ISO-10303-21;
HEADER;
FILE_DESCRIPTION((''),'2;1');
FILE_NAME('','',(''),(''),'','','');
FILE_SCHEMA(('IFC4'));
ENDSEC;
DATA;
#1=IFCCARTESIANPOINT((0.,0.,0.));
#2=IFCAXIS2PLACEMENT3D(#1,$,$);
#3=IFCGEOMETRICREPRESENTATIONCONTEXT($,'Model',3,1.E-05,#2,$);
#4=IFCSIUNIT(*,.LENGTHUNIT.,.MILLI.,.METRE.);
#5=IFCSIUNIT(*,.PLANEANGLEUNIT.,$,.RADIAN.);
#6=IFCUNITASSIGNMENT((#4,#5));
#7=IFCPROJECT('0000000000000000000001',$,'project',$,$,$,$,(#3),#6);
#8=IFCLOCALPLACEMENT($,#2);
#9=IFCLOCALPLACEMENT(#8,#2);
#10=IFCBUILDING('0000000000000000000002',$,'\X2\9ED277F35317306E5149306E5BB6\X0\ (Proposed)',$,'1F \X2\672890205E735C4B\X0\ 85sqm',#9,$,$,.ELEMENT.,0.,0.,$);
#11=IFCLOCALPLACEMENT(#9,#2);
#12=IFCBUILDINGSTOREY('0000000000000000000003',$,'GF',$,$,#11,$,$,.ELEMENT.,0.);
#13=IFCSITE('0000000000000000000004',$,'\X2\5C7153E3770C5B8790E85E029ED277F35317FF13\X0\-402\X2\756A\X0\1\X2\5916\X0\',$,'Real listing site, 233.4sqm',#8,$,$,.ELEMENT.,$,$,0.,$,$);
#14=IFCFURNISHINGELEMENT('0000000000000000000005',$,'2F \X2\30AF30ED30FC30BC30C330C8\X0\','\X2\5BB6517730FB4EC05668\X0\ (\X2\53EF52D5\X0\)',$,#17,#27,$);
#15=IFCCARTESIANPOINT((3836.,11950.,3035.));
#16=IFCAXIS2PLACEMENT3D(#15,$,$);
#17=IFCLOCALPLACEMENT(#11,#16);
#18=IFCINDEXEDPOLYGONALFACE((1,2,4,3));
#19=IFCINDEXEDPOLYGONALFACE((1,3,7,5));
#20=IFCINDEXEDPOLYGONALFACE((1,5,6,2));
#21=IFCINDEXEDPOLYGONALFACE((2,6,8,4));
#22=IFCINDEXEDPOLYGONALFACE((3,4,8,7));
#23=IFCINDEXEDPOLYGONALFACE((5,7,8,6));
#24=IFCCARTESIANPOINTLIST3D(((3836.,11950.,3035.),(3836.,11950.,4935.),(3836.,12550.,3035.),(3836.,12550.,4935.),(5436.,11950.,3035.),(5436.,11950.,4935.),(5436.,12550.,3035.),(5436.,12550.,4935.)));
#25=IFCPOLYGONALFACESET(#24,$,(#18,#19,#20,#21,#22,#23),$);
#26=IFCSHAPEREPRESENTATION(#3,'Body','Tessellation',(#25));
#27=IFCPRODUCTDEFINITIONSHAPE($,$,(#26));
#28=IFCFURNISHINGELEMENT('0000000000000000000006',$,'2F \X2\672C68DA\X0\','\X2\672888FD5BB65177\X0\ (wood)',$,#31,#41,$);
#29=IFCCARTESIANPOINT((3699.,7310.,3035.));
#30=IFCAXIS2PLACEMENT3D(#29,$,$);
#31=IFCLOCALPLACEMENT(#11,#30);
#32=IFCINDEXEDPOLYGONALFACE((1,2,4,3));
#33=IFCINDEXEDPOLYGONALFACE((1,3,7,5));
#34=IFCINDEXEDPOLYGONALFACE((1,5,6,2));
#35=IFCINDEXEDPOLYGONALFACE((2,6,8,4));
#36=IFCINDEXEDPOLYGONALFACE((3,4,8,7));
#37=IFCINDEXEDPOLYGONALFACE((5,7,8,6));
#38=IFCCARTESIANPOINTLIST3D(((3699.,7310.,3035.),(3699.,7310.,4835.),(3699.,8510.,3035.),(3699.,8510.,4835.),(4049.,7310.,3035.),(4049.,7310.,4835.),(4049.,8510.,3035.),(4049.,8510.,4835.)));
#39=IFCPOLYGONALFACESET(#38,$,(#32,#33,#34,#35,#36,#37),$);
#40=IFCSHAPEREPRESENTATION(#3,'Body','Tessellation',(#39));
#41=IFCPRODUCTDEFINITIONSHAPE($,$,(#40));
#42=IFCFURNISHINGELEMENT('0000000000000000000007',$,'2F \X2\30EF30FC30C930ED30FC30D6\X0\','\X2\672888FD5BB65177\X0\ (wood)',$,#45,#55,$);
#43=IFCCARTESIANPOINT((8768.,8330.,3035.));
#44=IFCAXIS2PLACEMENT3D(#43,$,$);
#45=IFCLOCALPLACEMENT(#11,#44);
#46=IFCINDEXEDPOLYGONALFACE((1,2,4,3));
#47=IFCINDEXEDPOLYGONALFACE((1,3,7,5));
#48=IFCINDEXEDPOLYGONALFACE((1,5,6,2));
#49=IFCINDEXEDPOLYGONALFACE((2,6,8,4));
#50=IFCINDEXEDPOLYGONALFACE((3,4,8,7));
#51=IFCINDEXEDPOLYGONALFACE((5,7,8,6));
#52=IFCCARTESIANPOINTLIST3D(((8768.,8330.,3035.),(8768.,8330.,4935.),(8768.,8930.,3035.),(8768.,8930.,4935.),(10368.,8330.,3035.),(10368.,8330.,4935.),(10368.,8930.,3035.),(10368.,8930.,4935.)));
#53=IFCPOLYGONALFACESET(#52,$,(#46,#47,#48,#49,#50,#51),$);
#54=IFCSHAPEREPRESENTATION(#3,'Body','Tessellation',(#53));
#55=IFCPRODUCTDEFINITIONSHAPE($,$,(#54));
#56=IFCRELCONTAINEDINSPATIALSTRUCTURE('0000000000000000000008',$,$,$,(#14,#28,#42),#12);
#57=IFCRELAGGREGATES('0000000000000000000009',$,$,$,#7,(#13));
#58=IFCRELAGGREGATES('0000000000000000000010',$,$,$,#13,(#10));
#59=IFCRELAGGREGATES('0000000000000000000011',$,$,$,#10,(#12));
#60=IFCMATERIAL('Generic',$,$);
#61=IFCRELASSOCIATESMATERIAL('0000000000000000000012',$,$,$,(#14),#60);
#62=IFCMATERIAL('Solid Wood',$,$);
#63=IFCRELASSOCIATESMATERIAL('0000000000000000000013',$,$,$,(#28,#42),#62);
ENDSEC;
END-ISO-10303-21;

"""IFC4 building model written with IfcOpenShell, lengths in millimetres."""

from ifc_helpers import new_model, si_unit, frame, frame_2d, origin, place, context, project, spatial, rectangle, extrude, material, element, save


model = new_model("IFC4")

# Units and contexts
model_context = context("Model", 3, precision=1e-05, world=origin())
ifc_project = project(units=[si_unit("LENGTHUNIT", "METRE", prefix="MILLI"), si_unit("PLANEANGLEUNIT", "RADIAN")], contexts=[model_context])

# Site, building, storey
site_placement = place(None, origin())
site = spatial("IfcSite", under=ifc_project, at=site_placement, Name="山口県宇部市黒石北３-402番1外", ObjectType="Real listing site, 233.4sqm", CompositionType="ELEMENT", RefElevation=0.0)
building_placement = place(site_placement, origin())
building = spatial("IfcBuilding", under=site, at=building_placement, Name="黒石北の光の家 (Proposed)", ObjectType="1F 木造平屋 85sqm", CompositionType="ELEMENT", ElevationOfRefHeight=0.0, ElevationOfTerrain=0.0)
storey_placement = place(building_placement, origin())
storey = spatial("IfcBuildingStorey", under=building, at=storey_placement, Name="GF", CompositionType="ELEMENT", Elevation=0.0)

# Shared definitions
ifc_material_1 = material(Name="Solid Wood")

# Shared definitions
ifc_material_2 = material(Name="Generic")

# Furnishing elements
furnishing_1_placement = place(storey_placement, frame((3836.0, 11950.0, 3035.0)))
element("IfcFurnishingElement", 1, at=furnishing_1_placement, inside=storey, material=ifc_material_2, Name="2F クローゼット", Description="家具・什器 (可動)", context=model_context, shape_type="SweptSolid", body=[
    extrude(rectangle(XDim=1600.0, YDim=600.0, at=frame_2d((800.0, 300.0))), frame((3836.0, 11950.0, 3035.0)), (0.0, 0.0, 1.0), 1900.0),
])
furnishing_2_placement = place(storey_placement, frame((3699.0, 7310.0, 3035.0)))
element("IfcFurnishingElement", 2, at=furnishing_2_placement, inside=storey, material=ifc_material_1, Name="2F 本棚", Description="木製家具 (wood)", context=model_context, shape_type="SweptSolid", body=[
    extrude(rectangle(XDim=350.0, YDim=1200.0, at=frame_2d((175.0, 600.0))), frame((3699.0, 7310.0, 3035.0)), (0.0, 0.0, 1.0), 1800.0),
])
furnishing_3_placement = place(storey_placement, frame((8768.0, 8330.0, 3035.0)))
element("IfcFurnishingElement", 3, at=furnishing_3_placement, inside=storey, material=ifc_material_1, Name="2F ワードローブ", Description="木製家具 (wood)", context=model_context, shape_type="SweptSolid", body=[
    extrude(rectangle(XDim=1600.0, YDim=600.0, at=frame_2d((800.0, 300.0))), frame((8768.0, 8330.0, 3035.0)), (0.0, 0.0, 1.0), 1900.0),
])

save(model, "model.ifc")
